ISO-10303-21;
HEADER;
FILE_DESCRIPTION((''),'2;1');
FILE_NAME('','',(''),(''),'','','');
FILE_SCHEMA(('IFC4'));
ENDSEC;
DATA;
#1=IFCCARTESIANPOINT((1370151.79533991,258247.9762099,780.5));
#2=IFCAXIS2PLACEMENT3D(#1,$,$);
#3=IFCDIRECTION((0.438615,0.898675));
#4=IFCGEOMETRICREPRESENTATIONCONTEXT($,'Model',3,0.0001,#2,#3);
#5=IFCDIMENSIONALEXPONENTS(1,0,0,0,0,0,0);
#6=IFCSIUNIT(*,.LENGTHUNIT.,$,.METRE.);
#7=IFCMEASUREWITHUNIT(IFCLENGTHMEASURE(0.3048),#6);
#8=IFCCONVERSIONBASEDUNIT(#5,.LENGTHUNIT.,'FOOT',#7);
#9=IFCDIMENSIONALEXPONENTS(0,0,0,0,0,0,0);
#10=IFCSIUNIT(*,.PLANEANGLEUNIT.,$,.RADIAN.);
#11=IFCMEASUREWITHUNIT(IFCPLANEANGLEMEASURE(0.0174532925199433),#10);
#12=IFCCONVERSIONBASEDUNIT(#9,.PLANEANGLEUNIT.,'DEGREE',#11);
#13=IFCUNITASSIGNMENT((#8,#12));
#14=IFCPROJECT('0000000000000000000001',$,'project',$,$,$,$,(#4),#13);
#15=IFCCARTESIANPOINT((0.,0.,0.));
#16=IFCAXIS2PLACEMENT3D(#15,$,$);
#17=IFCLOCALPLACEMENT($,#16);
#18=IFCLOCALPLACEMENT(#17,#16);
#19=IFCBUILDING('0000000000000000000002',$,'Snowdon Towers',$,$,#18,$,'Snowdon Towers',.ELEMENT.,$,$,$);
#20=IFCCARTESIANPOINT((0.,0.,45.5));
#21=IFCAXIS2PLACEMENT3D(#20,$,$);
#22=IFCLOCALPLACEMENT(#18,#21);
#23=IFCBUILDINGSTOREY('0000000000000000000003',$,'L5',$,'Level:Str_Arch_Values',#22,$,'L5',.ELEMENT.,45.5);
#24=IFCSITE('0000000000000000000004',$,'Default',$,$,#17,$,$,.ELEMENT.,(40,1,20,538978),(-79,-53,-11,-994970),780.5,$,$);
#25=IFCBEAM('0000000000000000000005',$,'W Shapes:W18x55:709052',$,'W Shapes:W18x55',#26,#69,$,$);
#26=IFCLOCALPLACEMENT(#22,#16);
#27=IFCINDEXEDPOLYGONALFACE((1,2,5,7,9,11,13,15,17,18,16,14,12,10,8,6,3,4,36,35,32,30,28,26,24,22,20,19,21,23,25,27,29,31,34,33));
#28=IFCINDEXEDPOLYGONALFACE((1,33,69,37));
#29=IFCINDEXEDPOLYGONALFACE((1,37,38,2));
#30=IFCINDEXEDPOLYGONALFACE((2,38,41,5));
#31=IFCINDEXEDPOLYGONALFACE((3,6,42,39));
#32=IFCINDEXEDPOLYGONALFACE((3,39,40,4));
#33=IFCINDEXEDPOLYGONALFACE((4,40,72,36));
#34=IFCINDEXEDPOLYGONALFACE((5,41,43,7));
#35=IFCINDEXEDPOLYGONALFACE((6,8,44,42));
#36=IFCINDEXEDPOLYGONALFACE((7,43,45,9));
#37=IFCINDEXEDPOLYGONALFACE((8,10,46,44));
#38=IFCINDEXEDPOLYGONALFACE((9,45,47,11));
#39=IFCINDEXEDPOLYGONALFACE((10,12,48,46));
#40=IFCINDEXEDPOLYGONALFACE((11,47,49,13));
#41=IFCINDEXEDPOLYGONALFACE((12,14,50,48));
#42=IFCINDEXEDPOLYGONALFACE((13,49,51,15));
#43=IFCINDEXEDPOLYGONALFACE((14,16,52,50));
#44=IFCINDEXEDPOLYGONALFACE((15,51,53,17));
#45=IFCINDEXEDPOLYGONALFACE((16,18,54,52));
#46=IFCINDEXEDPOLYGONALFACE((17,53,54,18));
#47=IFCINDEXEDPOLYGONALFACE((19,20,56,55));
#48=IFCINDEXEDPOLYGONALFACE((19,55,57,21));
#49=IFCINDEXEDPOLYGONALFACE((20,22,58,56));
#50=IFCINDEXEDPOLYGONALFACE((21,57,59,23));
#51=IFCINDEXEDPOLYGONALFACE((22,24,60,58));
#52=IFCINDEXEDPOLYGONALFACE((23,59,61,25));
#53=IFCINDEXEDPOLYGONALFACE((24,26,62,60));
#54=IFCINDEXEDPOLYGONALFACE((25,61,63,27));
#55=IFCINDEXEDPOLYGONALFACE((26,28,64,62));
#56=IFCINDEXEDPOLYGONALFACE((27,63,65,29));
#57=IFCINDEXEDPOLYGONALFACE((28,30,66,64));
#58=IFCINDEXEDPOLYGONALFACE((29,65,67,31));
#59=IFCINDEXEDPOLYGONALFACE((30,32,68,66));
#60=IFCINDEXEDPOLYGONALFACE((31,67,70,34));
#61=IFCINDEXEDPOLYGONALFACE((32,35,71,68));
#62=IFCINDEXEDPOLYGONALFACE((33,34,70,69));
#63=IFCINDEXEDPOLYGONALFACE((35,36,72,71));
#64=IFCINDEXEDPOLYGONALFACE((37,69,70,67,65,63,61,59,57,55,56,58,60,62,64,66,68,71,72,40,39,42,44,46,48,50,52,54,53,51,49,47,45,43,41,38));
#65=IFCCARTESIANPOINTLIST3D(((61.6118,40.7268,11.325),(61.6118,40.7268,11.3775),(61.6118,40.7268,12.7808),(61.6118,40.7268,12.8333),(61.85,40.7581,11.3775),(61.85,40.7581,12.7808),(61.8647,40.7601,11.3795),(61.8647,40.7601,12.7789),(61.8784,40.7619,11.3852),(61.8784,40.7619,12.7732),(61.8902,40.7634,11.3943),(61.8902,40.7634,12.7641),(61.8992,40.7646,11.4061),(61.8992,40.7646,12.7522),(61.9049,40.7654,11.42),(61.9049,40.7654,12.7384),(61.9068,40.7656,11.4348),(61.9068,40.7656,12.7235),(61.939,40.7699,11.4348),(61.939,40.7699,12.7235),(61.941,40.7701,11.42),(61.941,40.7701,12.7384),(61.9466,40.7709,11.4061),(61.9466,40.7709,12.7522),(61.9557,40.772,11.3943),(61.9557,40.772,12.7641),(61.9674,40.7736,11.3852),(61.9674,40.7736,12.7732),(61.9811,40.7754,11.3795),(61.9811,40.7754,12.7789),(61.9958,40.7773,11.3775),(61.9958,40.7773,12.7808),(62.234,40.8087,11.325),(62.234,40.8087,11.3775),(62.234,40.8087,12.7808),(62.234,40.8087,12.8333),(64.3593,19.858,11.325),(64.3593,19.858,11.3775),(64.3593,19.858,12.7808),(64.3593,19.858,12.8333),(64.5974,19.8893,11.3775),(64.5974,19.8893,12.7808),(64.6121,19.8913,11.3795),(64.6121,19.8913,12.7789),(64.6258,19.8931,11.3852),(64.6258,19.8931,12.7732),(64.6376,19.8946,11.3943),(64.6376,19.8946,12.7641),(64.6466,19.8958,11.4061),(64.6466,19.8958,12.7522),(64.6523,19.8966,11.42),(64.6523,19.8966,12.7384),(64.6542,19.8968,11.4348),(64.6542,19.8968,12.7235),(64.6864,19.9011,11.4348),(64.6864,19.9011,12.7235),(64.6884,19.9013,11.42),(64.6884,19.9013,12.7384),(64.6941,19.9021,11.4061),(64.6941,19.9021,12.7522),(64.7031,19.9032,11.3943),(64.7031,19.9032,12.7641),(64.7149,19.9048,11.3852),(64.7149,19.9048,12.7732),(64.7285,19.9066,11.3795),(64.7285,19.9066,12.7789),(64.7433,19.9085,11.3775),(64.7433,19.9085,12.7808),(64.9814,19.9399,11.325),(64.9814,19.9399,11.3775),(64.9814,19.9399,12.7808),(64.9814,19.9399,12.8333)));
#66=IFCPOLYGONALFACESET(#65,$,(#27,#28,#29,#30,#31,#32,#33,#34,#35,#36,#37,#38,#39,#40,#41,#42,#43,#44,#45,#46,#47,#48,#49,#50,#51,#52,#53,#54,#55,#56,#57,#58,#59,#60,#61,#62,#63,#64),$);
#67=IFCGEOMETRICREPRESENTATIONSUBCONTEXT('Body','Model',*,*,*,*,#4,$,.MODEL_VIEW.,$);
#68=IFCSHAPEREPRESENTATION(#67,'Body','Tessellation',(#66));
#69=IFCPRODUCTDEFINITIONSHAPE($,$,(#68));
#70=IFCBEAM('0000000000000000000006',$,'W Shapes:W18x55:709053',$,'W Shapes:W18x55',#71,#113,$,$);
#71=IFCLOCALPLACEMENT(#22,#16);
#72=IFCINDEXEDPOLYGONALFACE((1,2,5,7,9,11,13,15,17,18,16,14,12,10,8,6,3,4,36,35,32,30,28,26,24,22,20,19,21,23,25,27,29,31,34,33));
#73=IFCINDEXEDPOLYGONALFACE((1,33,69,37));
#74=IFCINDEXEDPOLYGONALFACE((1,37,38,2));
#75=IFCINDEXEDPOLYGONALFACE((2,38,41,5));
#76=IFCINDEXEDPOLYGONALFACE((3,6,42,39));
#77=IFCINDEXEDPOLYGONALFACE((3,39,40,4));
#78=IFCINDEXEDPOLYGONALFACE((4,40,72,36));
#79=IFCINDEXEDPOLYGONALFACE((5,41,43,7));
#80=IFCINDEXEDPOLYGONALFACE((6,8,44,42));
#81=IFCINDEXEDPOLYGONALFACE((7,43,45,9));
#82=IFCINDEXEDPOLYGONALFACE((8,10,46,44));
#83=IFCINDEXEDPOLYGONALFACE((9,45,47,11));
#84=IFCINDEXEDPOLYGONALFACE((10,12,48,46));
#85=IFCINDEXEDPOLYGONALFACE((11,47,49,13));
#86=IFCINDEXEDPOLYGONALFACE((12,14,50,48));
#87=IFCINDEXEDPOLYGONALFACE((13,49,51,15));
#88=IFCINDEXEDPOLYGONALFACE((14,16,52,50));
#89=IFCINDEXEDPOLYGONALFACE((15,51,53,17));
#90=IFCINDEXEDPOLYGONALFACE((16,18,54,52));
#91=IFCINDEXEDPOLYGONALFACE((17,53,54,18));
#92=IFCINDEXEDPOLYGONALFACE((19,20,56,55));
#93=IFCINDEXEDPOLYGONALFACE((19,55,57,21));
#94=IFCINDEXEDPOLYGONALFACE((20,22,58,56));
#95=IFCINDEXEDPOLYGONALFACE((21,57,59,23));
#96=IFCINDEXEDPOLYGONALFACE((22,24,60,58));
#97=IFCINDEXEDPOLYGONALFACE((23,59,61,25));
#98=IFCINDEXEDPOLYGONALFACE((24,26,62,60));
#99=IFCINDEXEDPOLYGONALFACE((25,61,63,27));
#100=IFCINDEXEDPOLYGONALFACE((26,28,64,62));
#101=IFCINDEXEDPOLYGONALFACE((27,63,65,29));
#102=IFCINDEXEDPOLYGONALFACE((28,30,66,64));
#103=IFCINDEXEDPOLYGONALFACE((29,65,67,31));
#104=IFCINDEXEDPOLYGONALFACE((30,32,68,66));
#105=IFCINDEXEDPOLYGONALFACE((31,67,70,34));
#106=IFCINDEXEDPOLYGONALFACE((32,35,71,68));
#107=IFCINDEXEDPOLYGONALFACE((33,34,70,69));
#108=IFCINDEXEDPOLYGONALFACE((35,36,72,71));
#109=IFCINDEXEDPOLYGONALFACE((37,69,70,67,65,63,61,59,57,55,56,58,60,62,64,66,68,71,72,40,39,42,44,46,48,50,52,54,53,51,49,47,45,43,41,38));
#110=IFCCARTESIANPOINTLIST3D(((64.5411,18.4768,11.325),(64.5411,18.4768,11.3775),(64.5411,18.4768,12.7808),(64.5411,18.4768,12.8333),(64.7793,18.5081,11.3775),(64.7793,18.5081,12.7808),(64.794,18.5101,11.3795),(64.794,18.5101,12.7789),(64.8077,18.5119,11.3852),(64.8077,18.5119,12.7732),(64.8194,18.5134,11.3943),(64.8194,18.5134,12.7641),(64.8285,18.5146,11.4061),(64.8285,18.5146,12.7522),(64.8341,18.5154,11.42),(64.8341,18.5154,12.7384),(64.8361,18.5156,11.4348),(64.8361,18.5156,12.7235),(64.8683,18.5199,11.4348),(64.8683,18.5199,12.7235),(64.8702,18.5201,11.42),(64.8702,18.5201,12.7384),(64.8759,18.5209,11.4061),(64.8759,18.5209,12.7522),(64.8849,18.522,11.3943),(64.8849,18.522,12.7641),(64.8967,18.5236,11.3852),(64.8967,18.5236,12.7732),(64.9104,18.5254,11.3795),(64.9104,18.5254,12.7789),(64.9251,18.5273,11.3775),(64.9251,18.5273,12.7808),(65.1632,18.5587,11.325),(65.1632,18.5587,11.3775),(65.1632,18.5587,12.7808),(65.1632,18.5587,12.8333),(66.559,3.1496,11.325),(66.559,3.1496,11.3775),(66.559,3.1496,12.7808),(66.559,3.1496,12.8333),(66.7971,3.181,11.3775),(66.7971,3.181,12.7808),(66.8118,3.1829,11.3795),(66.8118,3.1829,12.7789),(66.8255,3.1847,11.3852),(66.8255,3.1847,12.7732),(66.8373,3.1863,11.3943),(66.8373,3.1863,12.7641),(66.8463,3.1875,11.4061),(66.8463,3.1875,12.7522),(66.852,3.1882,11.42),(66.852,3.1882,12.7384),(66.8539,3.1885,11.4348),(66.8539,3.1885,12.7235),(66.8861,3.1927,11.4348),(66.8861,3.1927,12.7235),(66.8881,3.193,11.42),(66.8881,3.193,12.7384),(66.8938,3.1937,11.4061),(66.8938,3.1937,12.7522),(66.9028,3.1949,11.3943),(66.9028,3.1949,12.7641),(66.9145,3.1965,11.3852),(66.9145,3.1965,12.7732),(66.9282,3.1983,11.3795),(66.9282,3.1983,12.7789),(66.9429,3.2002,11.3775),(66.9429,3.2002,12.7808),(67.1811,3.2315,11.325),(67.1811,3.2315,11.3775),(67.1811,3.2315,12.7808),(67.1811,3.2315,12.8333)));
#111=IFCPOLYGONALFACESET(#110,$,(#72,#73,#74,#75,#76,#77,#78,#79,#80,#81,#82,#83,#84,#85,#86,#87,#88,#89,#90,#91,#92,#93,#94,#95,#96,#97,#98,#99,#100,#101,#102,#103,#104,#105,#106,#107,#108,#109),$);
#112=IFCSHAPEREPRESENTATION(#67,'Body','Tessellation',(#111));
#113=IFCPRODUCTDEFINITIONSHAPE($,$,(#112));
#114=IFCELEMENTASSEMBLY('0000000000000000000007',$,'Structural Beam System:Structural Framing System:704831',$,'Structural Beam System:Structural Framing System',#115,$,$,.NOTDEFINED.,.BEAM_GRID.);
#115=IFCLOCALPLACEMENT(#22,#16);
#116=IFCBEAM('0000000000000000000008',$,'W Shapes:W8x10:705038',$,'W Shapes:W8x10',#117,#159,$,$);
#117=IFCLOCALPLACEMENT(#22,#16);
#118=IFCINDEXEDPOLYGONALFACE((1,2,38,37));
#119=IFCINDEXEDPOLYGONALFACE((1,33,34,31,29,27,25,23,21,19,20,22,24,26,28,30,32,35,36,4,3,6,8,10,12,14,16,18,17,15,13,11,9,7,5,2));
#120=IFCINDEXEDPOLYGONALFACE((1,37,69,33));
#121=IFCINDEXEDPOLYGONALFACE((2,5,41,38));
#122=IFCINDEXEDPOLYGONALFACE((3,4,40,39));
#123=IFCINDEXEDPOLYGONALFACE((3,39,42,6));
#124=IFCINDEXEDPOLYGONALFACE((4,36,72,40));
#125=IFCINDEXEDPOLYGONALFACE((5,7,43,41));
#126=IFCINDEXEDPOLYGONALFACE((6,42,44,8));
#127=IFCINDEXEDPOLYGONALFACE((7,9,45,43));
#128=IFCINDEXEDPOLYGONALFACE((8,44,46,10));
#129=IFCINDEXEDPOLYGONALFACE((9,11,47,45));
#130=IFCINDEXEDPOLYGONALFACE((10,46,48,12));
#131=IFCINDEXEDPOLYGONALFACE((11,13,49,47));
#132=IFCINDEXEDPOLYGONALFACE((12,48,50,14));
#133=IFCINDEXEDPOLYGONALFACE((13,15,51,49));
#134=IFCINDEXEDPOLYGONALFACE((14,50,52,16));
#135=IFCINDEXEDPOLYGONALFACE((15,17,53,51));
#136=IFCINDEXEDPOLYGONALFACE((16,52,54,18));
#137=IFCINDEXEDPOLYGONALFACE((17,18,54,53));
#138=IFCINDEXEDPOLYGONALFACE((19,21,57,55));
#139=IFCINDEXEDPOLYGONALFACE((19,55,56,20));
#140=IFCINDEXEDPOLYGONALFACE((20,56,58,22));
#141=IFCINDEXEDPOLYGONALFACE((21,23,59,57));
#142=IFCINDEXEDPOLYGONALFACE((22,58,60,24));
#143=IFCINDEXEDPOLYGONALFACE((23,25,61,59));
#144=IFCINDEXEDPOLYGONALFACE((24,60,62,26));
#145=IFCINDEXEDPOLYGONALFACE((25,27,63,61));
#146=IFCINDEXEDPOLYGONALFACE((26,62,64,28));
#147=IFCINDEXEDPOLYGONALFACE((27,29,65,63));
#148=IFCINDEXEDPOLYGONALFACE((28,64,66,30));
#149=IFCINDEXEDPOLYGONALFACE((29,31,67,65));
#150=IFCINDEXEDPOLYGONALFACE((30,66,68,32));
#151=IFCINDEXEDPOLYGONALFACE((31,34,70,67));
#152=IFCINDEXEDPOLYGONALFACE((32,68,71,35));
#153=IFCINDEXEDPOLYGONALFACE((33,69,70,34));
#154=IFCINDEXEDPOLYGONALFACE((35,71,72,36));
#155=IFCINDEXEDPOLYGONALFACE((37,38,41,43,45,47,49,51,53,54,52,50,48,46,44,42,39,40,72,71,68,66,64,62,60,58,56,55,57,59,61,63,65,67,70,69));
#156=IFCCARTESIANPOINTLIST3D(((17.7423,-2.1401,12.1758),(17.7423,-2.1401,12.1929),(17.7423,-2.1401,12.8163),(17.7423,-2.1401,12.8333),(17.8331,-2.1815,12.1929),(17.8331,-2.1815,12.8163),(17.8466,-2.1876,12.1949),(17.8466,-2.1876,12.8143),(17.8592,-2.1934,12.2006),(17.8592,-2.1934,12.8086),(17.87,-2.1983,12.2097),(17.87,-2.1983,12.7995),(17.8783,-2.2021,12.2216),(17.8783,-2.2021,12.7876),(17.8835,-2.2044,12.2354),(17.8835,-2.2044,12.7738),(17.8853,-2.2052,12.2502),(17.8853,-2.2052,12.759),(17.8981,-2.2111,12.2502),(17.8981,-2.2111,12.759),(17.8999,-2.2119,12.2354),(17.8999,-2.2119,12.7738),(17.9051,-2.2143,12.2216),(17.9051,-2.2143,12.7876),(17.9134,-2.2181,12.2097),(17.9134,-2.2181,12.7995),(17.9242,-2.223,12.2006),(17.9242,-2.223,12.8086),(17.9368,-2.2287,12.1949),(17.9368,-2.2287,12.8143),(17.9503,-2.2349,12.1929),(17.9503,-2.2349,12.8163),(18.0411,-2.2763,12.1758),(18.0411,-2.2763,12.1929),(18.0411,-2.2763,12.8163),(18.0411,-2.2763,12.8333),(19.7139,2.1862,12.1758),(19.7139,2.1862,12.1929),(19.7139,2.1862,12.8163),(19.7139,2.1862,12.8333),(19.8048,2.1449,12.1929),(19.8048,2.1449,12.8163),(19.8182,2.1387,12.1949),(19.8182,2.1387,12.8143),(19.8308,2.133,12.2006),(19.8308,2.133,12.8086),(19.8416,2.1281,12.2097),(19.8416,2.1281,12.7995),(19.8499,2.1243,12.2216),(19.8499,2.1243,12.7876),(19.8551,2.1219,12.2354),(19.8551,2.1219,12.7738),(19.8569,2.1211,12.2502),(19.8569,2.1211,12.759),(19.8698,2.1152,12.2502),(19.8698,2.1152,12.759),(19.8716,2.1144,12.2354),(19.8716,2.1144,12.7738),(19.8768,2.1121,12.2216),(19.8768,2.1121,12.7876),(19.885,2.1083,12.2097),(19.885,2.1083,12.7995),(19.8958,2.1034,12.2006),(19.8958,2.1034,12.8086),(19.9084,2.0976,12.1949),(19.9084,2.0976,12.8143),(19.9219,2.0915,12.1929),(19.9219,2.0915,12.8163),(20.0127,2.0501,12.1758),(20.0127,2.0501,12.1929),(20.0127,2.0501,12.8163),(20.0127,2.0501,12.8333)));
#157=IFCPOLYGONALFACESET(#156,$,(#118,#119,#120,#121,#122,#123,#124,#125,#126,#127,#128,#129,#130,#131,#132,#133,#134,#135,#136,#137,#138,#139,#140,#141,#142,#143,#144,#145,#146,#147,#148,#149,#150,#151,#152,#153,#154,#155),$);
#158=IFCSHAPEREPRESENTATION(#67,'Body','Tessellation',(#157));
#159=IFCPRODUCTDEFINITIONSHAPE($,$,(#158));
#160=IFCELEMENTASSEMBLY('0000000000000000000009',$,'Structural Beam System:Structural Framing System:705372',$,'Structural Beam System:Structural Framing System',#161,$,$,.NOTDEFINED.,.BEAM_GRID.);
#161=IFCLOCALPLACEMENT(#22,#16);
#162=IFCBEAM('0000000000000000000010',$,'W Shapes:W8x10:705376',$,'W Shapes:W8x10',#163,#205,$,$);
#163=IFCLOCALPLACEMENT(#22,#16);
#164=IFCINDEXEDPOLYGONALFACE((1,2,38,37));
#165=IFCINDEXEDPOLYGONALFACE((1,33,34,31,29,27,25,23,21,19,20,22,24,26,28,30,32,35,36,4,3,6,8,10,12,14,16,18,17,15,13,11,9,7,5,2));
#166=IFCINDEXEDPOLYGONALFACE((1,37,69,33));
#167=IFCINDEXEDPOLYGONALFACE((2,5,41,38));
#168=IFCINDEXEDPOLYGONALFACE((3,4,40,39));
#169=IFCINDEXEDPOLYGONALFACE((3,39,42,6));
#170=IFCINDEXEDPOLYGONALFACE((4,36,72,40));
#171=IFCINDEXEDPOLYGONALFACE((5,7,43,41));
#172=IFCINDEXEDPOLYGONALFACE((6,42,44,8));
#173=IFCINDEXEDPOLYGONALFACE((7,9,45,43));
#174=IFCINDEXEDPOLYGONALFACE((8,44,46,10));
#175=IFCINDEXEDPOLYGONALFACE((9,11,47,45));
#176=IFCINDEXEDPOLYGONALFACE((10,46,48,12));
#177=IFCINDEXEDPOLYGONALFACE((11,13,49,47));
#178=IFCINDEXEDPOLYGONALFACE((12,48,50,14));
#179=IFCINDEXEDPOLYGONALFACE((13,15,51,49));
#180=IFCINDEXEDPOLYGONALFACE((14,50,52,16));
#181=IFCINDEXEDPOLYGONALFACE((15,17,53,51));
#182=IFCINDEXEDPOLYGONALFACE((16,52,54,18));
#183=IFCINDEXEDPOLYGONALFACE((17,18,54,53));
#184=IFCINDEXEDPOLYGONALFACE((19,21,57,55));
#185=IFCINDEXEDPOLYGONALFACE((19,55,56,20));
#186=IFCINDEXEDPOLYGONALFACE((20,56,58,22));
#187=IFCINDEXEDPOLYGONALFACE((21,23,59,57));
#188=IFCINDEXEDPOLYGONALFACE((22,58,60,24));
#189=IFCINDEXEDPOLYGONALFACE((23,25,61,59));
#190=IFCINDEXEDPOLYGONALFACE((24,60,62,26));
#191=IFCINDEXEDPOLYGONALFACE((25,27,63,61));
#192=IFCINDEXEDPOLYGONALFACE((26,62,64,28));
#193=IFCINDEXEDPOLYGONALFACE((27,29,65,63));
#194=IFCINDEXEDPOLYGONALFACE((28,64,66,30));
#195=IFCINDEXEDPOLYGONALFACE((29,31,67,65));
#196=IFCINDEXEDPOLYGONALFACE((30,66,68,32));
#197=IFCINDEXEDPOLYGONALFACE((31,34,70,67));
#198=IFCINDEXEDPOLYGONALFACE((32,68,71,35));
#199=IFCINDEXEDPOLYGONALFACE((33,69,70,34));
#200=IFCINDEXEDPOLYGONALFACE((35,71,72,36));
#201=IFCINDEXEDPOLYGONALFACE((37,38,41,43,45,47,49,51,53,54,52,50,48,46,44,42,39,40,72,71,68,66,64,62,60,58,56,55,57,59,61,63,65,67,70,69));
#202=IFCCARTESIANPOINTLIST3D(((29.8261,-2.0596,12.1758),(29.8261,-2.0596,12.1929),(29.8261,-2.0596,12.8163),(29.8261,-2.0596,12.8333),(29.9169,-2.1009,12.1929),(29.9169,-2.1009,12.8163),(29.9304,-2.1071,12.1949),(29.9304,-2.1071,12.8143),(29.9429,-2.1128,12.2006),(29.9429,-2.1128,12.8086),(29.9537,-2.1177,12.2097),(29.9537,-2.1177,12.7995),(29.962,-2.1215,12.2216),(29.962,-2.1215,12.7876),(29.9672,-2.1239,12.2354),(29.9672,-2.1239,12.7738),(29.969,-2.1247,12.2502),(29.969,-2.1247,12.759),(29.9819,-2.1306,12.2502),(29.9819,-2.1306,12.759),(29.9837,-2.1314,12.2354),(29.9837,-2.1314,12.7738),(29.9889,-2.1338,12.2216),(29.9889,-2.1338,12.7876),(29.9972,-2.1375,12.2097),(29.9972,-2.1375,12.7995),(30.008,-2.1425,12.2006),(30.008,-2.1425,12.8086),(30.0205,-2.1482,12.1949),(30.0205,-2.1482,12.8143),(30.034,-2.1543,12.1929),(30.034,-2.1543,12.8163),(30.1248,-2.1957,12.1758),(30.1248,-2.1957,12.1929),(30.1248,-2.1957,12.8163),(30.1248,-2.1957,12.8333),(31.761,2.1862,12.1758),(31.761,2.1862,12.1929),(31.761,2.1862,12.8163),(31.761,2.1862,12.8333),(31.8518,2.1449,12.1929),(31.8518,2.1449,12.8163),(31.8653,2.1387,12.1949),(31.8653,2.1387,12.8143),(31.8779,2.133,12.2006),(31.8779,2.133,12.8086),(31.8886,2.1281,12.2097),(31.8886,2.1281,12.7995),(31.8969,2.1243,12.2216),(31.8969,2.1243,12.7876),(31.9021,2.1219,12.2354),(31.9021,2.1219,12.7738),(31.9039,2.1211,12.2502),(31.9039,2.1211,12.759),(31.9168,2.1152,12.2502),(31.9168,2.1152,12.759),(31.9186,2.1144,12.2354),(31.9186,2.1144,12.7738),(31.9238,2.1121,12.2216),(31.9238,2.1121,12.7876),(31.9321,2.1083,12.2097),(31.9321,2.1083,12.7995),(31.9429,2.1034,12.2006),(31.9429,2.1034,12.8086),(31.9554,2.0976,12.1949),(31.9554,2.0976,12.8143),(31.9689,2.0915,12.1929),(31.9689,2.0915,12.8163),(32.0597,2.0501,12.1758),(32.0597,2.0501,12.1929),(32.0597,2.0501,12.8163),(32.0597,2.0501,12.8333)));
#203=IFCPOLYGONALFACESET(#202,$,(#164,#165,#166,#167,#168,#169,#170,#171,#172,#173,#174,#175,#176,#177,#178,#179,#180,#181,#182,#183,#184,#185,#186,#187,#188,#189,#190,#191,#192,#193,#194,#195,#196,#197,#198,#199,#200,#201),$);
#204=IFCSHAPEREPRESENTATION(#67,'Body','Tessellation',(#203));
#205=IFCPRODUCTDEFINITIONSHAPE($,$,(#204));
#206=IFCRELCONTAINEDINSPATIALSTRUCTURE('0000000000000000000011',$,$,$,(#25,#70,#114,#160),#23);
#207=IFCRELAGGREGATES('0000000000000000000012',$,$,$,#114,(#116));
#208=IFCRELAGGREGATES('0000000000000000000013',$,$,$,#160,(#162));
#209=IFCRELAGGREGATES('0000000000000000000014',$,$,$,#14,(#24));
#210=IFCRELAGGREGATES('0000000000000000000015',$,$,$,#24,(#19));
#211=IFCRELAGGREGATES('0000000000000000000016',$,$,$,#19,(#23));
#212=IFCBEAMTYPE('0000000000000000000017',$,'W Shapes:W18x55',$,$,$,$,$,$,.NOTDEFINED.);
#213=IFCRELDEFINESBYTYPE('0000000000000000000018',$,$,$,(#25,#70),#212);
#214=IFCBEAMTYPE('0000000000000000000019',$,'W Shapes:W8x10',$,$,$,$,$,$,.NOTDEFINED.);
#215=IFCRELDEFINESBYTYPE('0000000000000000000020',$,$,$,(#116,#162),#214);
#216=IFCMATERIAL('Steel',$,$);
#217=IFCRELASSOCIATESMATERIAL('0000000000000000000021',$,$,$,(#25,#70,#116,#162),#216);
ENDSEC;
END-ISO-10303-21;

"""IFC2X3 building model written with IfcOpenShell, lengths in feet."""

from ifc_helpers import new_model, entity, si_unit, converted_unit, direction, frame, frame_2d, origin, place, context, subcontext, project, spatial, i_section, extrude, material, type_object, element, aggregate, save


model = new_model("IFC2X3")

# Units and contexts
model_context = context("Model", 3, precision=0.0001, world=frame((1370151.79533991, 258247.9762099, 780.5)), true_north=direction((0.438615, 0.898675)))
body_context = subcontext(model_context, "Body", "Model", "MODEL_VIEW")
ifc_project = project(units=[converted_unit("LENGTHUNIT", "FOOT", entity("IfcLengthMeasure", 0.3048), si_unit("LENGTHUNIT", "METRE"), dimensions=[1, 0, 0, 0, 0, 0, 0]), converted_unit("PLANEANGLEUNIT", "DEGREE", entity("IfcPlaneAngleMeasure", 0.0174532925199433), si_unit("PLANEANGLEUNIT", "RADIAN"), dimensions=[0, 0, 0, 0, 0, 0, 0])], contexts=[model_context])

# Site, building, storey
site_placement = place(None, origin())
site = spatial("IfcSite", under=ifc_project, at=site_placement, Name="Default", CompositionType="ELEMENT", RefLatitude=(40, 1, 20, 538978), RefLongitude=(-79, -53, -11, -994970), RefElevation=780.5)
building_placement = place(site_placement, origin())
building = spatial("IfcBuilding", under=site, at=building_placement, Name="Snowdon Towers", LongName="Snowdon Towers", CompositionType="ELEMENT")
storey_placement = place(building_placement, frame((0.0, 0.0, 45.5)))
storey = spatial("IfcBuildingStorey", under=building, at=storey_placement, Name="L5", ObjectType="Level:Str_Arch_Values", LongName="L5", CompositionType="ELEMENT", Elevation=45.5)

# Shared definitions
ifc_material = material(Name="Steel")

# Beams
beam_type_1 = type_object("IfcBeamType", Name="W Shapes:W18x55", PredefinedType="NOTDEFINED")
beam_1_placement = place(storey_placement, frame((61.8201, 41.5489, 12.8333), z_axis=(0.0, 0.0, 1.0), x_axis=(0.130526, -0.991445, 0.0)))
element("IfcBeam", 1, at=beam_1_placement, inside=storey, type_object=beam_type_1, material=ifc_material, Name="W Shapes:W18x55:709052", ObjectType="W Shapes:W18x55", context=body_context, shape_type="SweptSolid", body=[
    extrude(i_section(OverallWidth=0.6275, OverallDepth=1.5083, WebThickness=0.0325, FlangeThickness=0.0525, FilletRadius=0.0573, at=frame_2d((0.0, 0.0), x_axis=(0.0, 1.0))), frame((0.7879, 0.0, -0.7542), z_axis=(1.0, 0.0, 0.0), x_axis=(0.0, 0.0, -1.0)), (0.0, 0.0, 1.0), 21.0489),
])
beam_2_placement = place(storey_placement, frame((64.7713, 19.1322, 12.8333), z_axis=(0.0, 0.0, 1.0), x_axis=(0.130526, -0.991445, 0.0)))
element("IfcBeam", 2, at=beam_2_placement, inside=storey, type_object=beam_type_1, material=ifc_material, Name="W Shapes:W18x55:709053", ObjectType="W Shapes:W18x55", context=body_context, shape_type="SweptSolid", body=[
    extrude(i_section(OverallWidth=0.6275, OverallDepth=1.5083, WebThickness=0.0325, FlangeThickness=0.0525, FilletRadius=0.0573, at=frame_2d((0.0, 0.0), x_axis=(0.0, 1.0))), frame((0.6198, 0.0, -0.7542), z_axis=(1.0, 0.0, 0.0), x_axis=(0.0, 0.0, -1.0)), (0.0, 0.0, 1.0), 15.4594),
])

# Element assembly, beam
assembly_1_placement = place(storey_placement, origin())
assembly_1 = element("IfcElementAssembly", 3, at=assembly_1_placement, inside=storey, Name="Structural Beam System:Structural Framing System:704831", ObjectType="Structural Beam System:Structural Framing System", AssemblyPlace="NOTDEFINED", PredefinedType="BEAM_GRID")
beam_type_2 = type_object("IfcBeamType", Name="W Shapes:W8x10", PredefinedType="NOTDEFINED")
beam_3_placement = place(assembly_1_placement, frame((17.7796, -2.4543, 12.8333), z_axis=(0.0, 0.0, 1.0), x_axis=(0.414693, 0.909961, 0.0)))
beam_3 = element("IfcBeam", 4, at=beam_3_placement, type_object=beam_type_2, material=ifc_material, Name="W Shapes:W8x10:705038", ObjectType="W Shapes:W8x10", context=body_context, shape_type="SweptSolid", body=[
    extrude(i_section(OverallWidth=0.3283, OverallDepth=0.6575, WebThickness=0.0142, FlangeThickness=0.0171, FilletRadius=0.0573, at=frame_2d((0.0, 0.0), x_axis=(0.0, 1.0))), frame((0.2704, 0.0, -0.3288), z_axis=(1.0, 0.0, 0.0), x_axis=(0.0, 0.0, -1.0)), (0.0, 0.0, 1.0), 4.7544),
])
aggregate(assembly_1, [beam_3])

# Element assembly, beam
assembly_2_placement = place(storey_placement, origin())
assembly_2 = element("IfcElementAssembly", 5, at=assembly_2_placement, inside=storey, Name="Structural Beam System:Structural Framing System:705372", ObjectType="Structural Beam System:Structural Framing System", AssemblyPlace="NOTDEFINED", PredefinedType="BEAM_GRID")
beam_4_placement = place(assembly_2_placement, frame((29.8633, -2.3737, 12.8333), z_axis=(0.0, 0.0, 1.0), x_axis=(0.414693, 0.909961, 0.0)))
beam_4 = element("IfcBeam", 6, at=beam_4_placement, type_object=beam_type_2, material=ifc_material, Name="W Shapes:W8x10:705376", ObjectType="W Shapes:W8x10", context=body_context, shape_type="SweptSolid", body=[
    extrude(i_section(OverallWidth=0.3283, OverallDepth=0.6575, WebThickness=0.0142, FlangeThickness=0.0171, FilletRadius=0.0573, at=frame_2d((0.0, 0.0), x_axis=(0.0, 1.0))), frame((0.2704, 0.0, -0.3288), z_axis=(1.0, 0.0, 0.0), x_axis=(0.0, 0.0, -1.0)), (0.0, 0.0, 1.0), 4.6659),
])

aggregate(assembly_2, [beam_4])

save(model, "model.ifc")
